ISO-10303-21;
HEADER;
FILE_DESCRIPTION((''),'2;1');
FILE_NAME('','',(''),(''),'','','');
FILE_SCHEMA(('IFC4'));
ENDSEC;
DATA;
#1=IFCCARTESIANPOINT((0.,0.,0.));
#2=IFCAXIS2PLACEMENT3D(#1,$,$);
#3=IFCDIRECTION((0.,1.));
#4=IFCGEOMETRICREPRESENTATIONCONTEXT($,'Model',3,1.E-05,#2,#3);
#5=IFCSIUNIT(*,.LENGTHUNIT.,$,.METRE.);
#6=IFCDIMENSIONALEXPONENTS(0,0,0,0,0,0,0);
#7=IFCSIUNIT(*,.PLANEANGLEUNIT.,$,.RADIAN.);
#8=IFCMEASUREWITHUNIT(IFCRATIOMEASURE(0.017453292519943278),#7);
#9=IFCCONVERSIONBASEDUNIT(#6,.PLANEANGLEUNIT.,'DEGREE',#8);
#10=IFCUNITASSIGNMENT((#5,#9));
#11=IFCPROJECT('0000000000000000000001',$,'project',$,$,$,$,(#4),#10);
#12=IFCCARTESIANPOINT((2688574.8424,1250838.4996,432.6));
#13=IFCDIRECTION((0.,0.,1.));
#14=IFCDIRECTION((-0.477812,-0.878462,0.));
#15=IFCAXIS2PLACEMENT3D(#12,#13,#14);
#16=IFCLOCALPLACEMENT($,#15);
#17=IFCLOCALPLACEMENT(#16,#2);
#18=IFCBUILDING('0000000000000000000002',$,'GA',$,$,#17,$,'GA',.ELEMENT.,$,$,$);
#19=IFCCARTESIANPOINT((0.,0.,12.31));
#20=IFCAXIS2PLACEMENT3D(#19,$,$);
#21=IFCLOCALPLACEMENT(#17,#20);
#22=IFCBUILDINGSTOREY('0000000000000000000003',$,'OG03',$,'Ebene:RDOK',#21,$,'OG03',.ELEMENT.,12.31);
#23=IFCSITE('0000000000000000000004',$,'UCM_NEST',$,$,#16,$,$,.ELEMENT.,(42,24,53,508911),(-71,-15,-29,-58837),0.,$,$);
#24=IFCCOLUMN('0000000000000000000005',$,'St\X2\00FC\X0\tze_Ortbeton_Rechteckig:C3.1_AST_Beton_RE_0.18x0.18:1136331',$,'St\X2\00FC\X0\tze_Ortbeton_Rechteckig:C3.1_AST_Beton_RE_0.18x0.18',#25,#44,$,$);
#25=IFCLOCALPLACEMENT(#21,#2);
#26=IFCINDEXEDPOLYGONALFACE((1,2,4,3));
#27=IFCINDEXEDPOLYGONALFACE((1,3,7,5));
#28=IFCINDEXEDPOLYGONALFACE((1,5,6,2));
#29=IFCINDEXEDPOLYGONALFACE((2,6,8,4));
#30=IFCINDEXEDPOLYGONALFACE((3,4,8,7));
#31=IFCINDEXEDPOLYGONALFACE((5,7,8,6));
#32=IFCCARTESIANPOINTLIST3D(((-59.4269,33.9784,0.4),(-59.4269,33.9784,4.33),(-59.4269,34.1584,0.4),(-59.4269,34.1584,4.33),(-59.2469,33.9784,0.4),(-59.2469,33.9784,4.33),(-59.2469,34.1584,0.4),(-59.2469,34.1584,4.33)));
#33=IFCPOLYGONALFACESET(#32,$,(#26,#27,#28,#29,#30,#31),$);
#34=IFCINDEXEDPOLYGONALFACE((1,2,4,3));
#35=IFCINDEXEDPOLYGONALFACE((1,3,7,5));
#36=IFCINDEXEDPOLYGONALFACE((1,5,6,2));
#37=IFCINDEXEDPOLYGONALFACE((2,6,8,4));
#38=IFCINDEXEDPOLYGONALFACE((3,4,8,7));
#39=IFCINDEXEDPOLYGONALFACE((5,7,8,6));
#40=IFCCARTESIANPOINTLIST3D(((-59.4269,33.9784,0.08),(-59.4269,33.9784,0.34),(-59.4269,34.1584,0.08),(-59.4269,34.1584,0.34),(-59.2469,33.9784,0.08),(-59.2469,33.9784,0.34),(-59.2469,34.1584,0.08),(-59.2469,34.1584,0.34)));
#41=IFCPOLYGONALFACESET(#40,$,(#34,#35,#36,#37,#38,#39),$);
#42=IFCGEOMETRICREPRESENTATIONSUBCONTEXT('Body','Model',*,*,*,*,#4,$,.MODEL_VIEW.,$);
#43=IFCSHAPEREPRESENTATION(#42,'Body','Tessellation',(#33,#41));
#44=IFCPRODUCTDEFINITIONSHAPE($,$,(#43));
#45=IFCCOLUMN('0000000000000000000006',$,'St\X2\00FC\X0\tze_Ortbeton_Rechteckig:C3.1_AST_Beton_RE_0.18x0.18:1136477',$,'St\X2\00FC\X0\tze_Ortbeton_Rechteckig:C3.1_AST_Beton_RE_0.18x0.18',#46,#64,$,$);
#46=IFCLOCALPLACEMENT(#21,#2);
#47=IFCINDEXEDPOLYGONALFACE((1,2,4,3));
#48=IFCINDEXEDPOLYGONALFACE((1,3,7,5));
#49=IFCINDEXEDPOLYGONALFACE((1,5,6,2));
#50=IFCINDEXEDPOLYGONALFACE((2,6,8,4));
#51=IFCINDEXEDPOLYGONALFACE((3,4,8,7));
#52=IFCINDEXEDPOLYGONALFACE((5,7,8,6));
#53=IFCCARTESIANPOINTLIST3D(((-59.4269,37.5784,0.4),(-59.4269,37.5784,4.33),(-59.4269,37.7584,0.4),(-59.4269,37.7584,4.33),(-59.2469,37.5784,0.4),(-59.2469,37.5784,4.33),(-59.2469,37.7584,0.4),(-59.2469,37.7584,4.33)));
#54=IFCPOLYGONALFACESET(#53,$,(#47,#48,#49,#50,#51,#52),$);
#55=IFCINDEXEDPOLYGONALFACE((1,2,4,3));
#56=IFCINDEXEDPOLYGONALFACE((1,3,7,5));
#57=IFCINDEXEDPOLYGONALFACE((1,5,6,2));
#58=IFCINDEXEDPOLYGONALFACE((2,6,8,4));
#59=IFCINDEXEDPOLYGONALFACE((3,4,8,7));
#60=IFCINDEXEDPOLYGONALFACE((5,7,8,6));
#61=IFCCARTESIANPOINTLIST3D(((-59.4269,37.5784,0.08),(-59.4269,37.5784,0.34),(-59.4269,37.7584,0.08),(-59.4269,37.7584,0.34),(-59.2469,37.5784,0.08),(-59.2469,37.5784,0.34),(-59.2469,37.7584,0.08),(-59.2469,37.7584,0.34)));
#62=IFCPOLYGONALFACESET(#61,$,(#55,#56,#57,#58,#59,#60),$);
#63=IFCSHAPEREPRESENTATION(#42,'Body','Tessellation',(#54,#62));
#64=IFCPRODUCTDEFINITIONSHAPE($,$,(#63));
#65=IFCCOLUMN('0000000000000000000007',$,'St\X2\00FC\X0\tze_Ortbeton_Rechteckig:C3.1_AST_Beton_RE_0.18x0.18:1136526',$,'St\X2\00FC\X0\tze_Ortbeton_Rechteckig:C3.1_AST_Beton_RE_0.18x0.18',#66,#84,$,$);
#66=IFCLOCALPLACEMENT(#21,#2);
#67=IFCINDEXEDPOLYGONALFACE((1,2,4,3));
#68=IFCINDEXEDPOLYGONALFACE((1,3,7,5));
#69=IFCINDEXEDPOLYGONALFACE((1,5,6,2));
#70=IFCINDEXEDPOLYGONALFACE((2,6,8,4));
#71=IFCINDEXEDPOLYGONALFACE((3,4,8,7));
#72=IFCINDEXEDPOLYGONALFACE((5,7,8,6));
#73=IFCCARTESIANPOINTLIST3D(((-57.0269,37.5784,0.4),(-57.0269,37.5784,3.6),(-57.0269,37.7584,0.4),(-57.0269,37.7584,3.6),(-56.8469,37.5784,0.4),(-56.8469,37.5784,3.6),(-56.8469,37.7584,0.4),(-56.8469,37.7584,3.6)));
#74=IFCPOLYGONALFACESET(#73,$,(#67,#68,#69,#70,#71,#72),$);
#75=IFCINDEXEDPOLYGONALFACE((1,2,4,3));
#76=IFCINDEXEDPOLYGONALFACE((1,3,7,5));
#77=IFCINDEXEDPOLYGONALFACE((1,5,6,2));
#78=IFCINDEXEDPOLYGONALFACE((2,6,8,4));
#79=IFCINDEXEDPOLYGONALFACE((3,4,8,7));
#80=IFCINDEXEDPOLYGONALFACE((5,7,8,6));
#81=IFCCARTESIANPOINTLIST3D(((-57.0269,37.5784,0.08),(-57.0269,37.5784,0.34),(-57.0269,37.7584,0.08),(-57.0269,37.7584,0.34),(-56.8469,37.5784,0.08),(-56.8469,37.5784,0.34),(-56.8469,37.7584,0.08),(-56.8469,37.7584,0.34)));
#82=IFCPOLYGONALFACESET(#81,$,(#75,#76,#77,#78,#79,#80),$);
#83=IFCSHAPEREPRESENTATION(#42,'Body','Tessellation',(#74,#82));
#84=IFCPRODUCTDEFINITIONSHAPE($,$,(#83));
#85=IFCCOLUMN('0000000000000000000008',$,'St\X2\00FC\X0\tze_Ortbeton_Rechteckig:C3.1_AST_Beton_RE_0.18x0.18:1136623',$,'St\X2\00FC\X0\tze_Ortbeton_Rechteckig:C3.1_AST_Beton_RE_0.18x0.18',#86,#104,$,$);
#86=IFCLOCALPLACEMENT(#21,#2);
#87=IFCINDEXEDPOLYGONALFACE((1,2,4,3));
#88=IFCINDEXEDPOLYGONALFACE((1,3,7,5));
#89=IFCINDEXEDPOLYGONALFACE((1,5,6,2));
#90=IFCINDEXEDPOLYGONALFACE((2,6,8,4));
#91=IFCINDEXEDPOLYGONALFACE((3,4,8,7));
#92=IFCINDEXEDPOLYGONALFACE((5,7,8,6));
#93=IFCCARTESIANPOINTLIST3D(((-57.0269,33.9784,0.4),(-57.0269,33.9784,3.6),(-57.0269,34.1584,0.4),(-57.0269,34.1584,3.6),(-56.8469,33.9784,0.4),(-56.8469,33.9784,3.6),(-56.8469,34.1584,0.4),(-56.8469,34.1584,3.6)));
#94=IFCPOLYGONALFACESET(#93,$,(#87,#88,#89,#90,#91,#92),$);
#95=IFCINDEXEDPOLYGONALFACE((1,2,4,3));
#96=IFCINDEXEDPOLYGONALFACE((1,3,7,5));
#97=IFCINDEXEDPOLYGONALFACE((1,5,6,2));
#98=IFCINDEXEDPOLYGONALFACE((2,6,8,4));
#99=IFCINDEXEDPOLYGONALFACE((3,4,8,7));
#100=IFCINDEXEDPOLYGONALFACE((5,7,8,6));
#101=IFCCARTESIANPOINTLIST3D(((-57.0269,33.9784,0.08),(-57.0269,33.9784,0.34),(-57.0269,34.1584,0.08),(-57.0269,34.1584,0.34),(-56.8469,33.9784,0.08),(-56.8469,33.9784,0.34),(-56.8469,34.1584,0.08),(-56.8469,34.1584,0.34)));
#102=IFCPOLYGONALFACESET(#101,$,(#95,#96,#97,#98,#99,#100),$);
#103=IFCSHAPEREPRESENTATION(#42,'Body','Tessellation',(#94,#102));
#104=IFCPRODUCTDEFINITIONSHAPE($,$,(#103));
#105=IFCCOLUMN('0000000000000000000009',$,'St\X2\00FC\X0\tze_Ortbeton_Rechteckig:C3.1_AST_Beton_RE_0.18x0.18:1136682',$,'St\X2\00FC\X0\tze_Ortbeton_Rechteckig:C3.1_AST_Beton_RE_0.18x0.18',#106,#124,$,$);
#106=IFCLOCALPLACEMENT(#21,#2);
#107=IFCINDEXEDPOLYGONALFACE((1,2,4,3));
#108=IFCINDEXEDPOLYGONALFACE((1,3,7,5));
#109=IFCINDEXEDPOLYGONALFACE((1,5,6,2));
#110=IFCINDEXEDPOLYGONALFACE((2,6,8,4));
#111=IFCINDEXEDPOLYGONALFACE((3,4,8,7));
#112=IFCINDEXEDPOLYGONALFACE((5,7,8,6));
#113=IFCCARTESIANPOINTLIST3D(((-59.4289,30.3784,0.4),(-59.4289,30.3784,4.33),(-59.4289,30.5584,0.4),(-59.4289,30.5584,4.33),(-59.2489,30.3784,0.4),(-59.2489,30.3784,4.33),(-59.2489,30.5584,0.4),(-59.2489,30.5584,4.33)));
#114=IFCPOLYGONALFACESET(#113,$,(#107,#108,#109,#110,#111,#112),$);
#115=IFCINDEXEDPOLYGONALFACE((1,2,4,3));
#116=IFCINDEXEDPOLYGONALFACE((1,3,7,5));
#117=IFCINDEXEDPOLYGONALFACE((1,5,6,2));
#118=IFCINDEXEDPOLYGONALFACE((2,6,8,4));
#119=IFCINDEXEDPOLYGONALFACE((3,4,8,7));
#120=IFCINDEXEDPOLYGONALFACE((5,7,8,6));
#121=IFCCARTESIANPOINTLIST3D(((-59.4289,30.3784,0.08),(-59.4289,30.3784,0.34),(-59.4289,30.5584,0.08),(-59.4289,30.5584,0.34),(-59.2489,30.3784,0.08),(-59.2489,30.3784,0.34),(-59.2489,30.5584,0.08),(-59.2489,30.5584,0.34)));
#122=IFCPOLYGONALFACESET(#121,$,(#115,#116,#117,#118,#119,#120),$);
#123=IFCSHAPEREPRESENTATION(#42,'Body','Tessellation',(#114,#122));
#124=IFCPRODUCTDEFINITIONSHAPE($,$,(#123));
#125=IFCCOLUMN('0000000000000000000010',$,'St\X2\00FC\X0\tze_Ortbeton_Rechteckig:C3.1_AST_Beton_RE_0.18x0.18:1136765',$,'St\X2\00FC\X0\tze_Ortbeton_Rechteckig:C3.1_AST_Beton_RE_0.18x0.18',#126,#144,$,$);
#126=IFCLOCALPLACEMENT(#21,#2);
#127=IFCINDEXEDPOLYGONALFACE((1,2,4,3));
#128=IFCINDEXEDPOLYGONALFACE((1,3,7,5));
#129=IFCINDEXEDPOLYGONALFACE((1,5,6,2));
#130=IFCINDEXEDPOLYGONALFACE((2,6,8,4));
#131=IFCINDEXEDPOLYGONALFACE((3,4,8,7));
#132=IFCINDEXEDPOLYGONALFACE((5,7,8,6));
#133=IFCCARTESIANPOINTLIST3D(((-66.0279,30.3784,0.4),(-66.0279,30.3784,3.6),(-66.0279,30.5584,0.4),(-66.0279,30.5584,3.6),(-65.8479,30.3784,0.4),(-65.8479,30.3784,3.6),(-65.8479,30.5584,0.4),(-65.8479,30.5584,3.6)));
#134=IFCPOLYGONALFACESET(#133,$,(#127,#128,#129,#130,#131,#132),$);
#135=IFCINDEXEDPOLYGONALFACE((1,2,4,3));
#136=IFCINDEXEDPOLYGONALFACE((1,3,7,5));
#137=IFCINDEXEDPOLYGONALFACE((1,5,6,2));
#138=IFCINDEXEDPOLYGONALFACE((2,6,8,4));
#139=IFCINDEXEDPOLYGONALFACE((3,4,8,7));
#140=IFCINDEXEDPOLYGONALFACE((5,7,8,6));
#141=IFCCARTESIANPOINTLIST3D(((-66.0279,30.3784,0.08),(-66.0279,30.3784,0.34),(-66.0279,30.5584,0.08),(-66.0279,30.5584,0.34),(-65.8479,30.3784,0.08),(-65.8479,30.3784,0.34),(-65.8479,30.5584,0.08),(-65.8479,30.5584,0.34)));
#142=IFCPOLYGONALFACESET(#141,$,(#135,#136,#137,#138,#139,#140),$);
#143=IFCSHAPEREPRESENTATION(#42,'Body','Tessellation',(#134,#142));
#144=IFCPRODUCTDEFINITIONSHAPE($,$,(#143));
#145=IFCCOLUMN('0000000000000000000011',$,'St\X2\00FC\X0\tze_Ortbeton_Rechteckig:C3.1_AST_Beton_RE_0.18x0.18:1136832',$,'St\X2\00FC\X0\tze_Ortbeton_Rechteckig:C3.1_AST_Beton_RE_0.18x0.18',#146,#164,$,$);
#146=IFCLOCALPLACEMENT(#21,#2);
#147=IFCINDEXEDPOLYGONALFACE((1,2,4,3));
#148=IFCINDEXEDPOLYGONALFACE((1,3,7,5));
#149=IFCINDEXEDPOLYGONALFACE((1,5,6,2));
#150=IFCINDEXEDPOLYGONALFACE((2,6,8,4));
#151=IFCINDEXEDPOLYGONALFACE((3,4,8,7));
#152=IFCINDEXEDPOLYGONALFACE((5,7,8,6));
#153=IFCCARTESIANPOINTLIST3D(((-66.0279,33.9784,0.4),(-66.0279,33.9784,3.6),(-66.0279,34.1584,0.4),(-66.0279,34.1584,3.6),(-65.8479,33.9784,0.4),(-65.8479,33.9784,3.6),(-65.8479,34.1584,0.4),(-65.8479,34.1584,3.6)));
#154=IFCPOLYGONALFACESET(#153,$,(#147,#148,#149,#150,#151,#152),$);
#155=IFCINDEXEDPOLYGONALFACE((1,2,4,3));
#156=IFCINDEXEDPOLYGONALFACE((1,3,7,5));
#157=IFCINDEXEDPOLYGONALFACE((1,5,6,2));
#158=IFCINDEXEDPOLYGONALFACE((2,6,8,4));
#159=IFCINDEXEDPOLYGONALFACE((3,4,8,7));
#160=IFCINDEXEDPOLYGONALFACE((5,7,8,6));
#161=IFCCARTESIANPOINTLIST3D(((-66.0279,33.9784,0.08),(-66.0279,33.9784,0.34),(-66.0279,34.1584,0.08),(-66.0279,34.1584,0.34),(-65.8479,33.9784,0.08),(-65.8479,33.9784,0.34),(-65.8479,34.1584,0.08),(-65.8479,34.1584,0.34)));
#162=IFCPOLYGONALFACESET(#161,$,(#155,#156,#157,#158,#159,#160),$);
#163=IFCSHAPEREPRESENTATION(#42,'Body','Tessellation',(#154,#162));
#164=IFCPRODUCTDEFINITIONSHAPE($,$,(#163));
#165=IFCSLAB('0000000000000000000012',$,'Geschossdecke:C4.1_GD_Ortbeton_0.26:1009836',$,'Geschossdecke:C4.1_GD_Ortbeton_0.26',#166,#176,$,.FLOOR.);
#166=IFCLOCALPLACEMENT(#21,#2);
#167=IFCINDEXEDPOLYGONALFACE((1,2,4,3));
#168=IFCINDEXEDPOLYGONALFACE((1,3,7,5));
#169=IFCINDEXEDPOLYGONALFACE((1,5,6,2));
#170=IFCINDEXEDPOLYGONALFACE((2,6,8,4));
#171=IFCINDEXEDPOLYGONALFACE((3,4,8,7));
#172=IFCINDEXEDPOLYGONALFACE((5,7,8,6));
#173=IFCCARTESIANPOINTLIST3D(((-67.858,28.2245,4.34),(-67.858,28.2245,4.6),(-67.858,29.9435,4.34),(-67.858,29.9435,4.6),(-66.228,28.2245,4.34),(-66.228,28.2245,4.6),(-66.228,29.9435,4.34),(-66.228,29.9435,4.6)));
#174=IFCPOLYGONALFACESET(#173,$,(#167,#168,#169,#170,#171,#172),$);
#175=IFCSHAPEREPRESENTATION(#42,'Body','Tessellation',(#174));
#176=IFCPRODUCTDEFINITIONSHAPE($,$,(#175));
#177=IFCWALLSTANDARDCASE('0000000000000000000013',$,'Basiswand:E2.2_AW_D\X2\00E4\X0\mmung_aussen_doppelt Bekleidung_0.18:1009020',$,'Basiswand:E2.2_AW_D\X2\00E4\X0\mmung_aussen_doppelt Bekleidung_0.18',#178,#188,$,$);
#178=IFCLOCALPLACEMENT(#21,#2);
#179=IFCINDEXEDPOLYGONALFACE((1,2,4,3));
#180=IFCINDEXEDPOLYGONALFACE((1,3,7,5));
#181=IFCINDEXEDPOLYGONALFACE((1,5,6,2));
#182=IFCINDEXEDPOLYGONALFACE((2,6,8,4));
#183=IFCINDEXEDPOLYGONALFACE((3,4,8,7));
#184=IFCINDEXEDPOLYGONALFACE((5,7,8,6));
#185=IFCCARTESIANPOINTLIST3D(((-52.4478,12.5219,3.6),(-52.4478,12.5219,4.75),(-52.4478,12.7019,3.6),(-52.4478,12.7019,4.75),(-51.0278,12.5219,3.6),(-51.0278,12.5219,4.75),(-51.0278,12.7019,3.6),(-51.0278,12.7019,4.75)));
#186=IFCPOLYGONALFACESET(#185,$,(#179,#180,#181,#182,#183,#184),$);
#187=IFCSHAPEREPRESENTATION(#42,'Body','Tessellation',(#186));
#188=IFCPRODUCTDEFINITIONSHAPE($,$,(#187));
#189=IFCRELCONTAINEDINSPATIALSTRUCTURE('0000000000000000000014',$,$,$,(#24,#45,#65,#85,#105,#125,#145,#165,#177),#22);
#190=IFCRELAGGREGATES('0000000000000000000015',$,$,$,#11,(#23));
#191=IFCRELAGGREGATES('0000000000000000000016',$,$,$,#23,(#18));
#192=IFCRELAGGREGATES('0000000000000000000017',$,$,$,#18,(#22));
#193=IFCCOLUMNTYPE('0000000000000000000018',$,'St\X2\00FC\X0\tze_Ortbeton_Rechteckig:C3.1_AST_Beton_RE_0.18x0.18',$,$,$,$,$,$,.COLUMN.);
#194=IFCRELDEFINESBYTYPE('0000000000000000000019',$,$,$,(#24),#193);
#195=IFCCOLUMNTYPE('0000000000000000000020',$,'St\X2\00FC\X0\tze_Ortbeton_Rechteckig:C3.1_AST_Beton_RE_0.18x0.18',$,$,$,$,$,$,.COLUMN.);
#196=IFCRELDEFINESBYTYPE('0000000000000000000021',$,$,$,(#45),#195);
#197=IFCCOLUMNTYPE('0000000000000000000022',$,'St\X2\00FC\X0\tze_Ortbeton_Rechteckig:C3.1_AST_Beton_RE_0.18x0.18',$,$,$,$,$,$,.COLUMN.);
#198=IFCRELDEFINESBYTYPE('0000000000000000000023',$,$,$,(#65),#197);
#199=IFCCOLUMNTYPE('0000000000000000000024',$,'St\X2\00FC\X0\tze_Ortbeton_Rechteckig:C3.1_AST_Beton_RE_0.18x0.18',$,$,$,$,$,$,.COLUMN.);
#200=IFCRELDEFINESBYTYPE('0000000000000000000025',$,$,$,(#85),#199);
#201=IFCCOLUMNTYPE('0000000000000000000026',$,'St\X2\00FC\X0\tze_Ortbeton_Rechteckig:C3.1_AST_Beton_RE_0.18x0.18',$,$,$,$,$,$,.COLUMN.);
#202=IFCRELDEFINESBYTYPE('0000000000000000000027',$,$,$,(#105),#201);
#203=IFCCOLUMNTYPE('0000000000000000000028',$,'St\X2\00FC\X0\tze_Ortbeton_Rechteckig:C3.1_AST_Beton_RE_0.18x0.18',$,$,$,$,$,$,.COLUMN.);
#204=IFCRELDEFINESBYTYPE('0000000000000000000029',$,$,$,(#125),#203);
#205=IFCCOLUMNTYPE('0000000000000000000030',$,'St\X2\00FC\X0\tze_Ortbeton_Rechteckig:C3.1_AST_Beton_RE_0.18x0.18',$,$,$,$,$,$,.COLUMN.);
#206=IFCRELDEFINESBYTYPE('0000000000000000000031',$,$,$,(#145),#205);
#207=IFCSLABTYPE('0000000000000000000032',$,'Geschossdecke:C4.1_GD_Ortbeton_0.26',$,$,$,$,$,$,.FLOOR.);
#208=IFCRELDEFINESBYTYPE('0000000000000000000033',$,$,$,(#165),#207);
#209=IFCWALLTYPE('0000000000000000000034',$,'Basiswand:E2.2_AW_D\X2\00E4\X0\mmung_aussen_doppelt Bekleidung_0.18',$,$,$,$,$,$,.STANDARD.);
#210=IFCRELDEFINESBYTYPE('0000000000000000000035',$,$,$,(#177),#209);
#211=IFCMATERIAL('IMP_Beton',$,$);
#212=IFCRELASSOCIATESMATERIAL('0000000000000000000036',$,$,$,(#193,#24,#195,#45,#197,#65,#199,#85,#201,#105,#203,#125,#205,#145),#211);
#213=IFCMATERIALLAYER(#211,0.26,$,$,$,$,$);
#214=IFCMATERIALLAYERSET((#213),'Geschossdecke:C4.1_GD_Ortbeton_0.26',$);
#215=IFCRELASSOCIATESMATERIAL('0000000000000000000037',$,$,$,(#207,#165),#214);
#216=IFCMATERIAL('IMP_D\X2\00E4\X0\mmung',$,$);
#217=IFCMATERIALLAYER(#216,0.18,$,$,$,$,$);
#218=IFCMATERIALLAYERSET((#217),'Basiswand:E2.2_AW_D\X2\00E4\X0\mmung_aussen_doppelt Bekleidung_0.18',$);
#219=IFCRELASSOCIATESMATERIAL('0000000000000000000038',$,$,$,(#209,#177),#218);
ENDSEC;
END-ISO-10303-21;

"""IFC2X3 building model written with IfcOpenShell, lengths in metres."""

from ifc_helpers import new_model, entity, si_unit, converted_unit, direction, frame, frame_2d, origin, origin_2d_with_axis, place, context, subcontext, project, spatial, rectangle, extrude, source, transform, mapped, material, layer, layer_set, layer_usage, type_object, type_shapes, element, save


model = new_model("IFC2X3")

# Units and contexts
model_context = context("Model", 3, precision=1e-05, world=origin(), true_north=direction((0.0, 1.0)))
body_context = subcontext(model_context, "Body", "Model", "MODEL_VIEW")
ifc_project = project(units=[si_unit("LENGTHUNIT", "METRE"), converted_unit("PLANEANGLEUNIT", "DEGREE", entity("IfcRatioMeasure", 0.017453292519943278), si_unit("PLANEANGLEUNIT", "RADIAN"), dimensions=[0, 0, 0, 0, 0, 0, 0])], contexts=[model_context])

# Site, building, storey
site_placement = place(None, frame((2688574.8424, 1250838.4996, 432.6), z_axis=(0.0, 0.0, 1.0), x_axis=(-0.477812, -0.878462, 0.0)))
site = spatial("IfcSite", under=ifc_project, at=site_placement, Name="UCM_NEST", CompositionType="ELEMENT", RefLatitude=(42, 24, 53, 508911), RefLongitude=(-71, -15, -29, -58837), RefElevation=0.0)
building_placement = place(site_placement, origin())
building = spatial("IfcBuilding", under=site, at=building_placement, Name="GA", LongName="GA", CompositionType="ELEMENT")
storey_placement = place(building_placement, frame((0.0, 0.0, 12.31)))
storey = spatial("IfcBuildingStorey", under=building, at=storey_placement, Name="OG03", ObjectType="Ebene:RDOK", LongName="OG03", CompositionType="ELEMENT", Elevation=12.31)

# Columns
ifc_material_1 = material(Name="IMP_Beton")
column_type_1 = type_object("IfcColumnType", Name="Stütze_Ortbeton_Rechteckig:C3.1_AST_Beton_RE_0.18x0.18", PredefinedType="COLUMN", material=ifc_material_1)
shared_shape_1 = source(origin(), body_context, "Body", "SweptSolid", [
    extrude(rectangle(XDim=0.18, YDim=0.18, at=frame_2d((0.0, 0.0), x_axis=(1.0, 0.0))), frame((-59.3369, 34.0684, 12.71), z_axis=(0.0, 0.0, 1.0), x_axis=(0.0, -1.0, 0.0)), (0.0, 0.0, 1.0), 3.93),
    extrude(rectangle(XDim=0.18, YDim=0.18, at=frame_2d((0.0, 0.0), x_axis=(1.0, 0.0))), frame((-59.3369, 34.0684, 12.39), z_axis=(0.0, 0.0, 1.0), x_axis=(0.0, -1.0, 0.0)), (0.0, 0.0, 1.0), 0.26),
])
type_shapes(column_type_1, [shared_shape_1])
column_1_placement = place(storey_placement, frame((0.0, 0.0, -12.31)))
element("IfcColumn", 1, at=column_1_placement, inside=storey, type_object=column_type_1, material=ifc_material_1, Name="Stütze_Ortbeton_Rechteckig:C3.1_AST_Beton_RE_0.18x0.18:1136331", ObjectType="Stütze_Ortbeton_Rechteckig:C3.1_AST_Beton_RE_0.18x0.18", context=body_context, shape_type="MappedRepresentation", body=[
    mapped(shared_shape_1, transform((0.0, 0.0, 0.0), scale=1.0)),
])
column_type_2 = type_object("IfcColumnType", Name="Stütze_Ortbeton_Rechteckig:C3.1_AST_Beton_RE_0.18x0.18", PredefinedType="COLUMN", material=ifc_material_1)
shared_shape_2 = source(origin(), body_context, "Body", "SweptSolid", [
    extrude(rectangle(XDim=0.18, YDim=0.18, at=frame_2d((0.0, 0.0), x_axis=(1.0, 0.0))), frame((-59.3369, 37.6684, 12.71), z_axis=(0.0, 0.0, 1.0), x_axis=(0.0, -1.0, 0.0)), (0.0, 0.0, 1.0), 3.93),
    extrude(rectangle(XDim=0.18, YDim=0.18, at=frame_2d((0.0, 0.0), x_axis=(1.0, 0.0))), frame((-59.3369, 37.6684, 12.39), z_axis=(0.0, 0.0, 1.0), x_axis=(0.0, -1.0, 0.0)), (0.0, 0.0, 1.0), 0.26),
])
type_shapes(column_type_2, [shared_shape_2])
column_2_placement = place(storey_placement, frame((0.0, 0.0, -12.31)))
element("IfcColumn", 2, at=column_2_placement, inside=storey, type_object=column_type_2, material=ifc_material_1, Name="Stütze_Ortbeton_Rechteckig:C3.1_AST_Beton_RE_0.18x0.18:1136477", ObjectType="Stütze_Ortbeton_Rechteckig:C3.1_AST_Beton_RE_0.18x0.18", context=body_context, shape_type="MappedRepresentation", body=[
    mapped(shared_shape_2, transform((0.0, 0.0, 0.0), scale=1.0)),
])
column_type_3 = type_object("IfcColumnType", Name="Stütze_Ortbeton_Rechteckig:C3.1_AST_Beton_RE_0.18x0.18", PredefinedType="COLUMN", material=ifc_material_1)
shared_shape_3 = source(origin(), body_context, "Body", "SweptSolid", [
    extrude(rectangle(XDim=0.18, YDim=0.18, at=origin_2d_with_axis()), frame((-56.9369, 37.6684, 12.71), z_axis=(0.0, 0.0, 1.0), x_axis=(0.0, -1.0, 0.0)), (0.0, 0.0, 1.0), 3.2),
    extrude(rectangle(XDim=0.18, YDim=0.18, at=origin_2d_with_axis()), frame((-56.9369, 37.6684, 12.39), z_axis=(0.0, 0.0, 1.0), x_axis=(0.0, -1.0, 0.0)), (0.0, 0.0, 1.0), 0.26),
])
type_shapes(column_type_3, [shared_shape_3])
column_3_placement = place(storey_placement, frame((0.0, 0.0, -12.31)))
element("IfcColumn", 3, at=column_3_placement, inside=storey, type_object=column_type_3, material=ifc_material_1, Name="Stütze_Ortbeton_Rechteckig:C3.1_AST_Beton_RE_0.18x0.18:1136526", ObjectType="Stütze_Ortbeton_Rechteckig:C3.1_AST_Beton_RE_0.18x0.18", context=body_context, shape_type="MappedRepresentation", body=[
    mapped(shared_shape_3, transform((0.0, 0.0, 0.0), scale=1.0)),
])
column_type_4 = type_object("IfcColumnType", Name="Stütze_Ortbeton_Rechteckig:C3.1_AST_Beton_RE_0.18x0.18", PredefinedType="COLUMN", material=ifc_material_1)
shared_shape_4 = source(origin(), body_context, "Body", "SweptSolid", [
    extrude(rectangle(XDim=0.18, YDim=0.18, at=frame_2d((0.0, 0.0), x_axis=(1.0, 0.0))), frame((-56.9369, 34.0684, 12.71), z_axis=(0.0, 0.0, 1.0), x_axis=(0.0, -1.0, 0.0)), (0.0, 0.0, 1.0), 3.2),
    extrude(rectangle(XDim=0.18, YDim=0.18, at=frame_2d((0.0, 0.0), x_axis=(1.0, 0.0))), frame((-56.9369, 34.0684, 12.39), z_axis=(0.0, 0.0, 1.0), x_axis=(0.0, -1.0, 0.0)), (0.0, 0.0, 1.0), 0.26),
])
type_shapes(column_type_4, [shared_shape_4])
column_4_placement = place(storey_placement, frame((0.0, 0.0, -12.31)))
element("IfcColumn", 4, at=column_4_placement, inside=storey, type_object=column_type_4, material=ifc_material_1, Name="Stütze_Ortbeton_Rechteckig:C3.1_AST_Beton_RE_0.18x0.18:1136623", ObjectType="Stütze_Ortbeton_Rechteckig:C3.1_AST_Beton_RE_0.18x0.18", context=body_context, shape_type="MappedRepresentation", body=[
    mapped(shared_shape_4, transform((0.0, 0.0, 0.0), scale=1.0)),
])
column_type_5 = type_object("IfcColumnType", Name="Stütze_Ortbeton_Rechteckig:C3.1_AST_Beton_RE_0.18x0.18", PredefinedType="COLUMN", material=ifc_material_1)
shared_shape_5 = source(origin(), body_context, "Body", "SweptSolid", [
    extrude(rectangle(XDim=0.18, YDim=0.18, at=frame_2d((0.0, 0.0), x_axis=(1.0, 0.0))), frame((-59.3389, 30.4684, 12.71), z_axis=(0.0, 0.0, 1.0), x_axis=(0.0, -1.0, 0.0)), (0.0, 0.0, 1.0), 3.93),
    extrude(rectangle(XDim=0.18, YDim=0.18, at=frame_2d((0.0, 0.0), x_axis=(1.0, 0.0))), frame((-59.3389, 30.4684, 12.39), z_axis=(0.0, 0.0, 1.0), x_axis=(0.0, -1.0, 0.0)), (0.0, 0.0, 1.0), 0.26),
])
type_shapes(column_type_5, [shared_shape_5])
column_5_placement = place(storey_placement, frame((0.0, 0.0, -12.31)))
element("IfcColumn", 5, at=column_5_placement, inside=storey, type_object=column_type_5, material=ifc_material_1, Name="Stütze_Ortbeton_Rechteckig:C3.1_AST_Beton_RE_0.18x0.18:1136682", ObjectType="Stütze_Ortbeton_Rechteckig:C3.1_AST_Beton_RE_0.18x0.18", context=body_context, shape_type="MappedRepresentation", body=[
    mapped(shared_shape_5, transform((0.0, 0.0, 0.0), scale=1.0)),
])
column_type_6 = type_object("IfcColumnType", Name="Stütze_Ortbeton_Rechteckig:C3.1_AST_Beton_RE_0.18x0.18", PredefinedType="COLUMN", material=ifc_material_1)
shared_shape_6 = source(origin(), body_context, "Body", "SweptSolid", [
    extrude(rectangle(XDim=0.18, YDim=0.18, at=origin_2d_with_axis()), frame((-65.9379, 30.4684, 12.71), z_axis=(0.0, 0.0, 1.0), x_axis=(0.0, -1.0, 0.0)), (0.0, 0.0, 1.0), 3.2),
    extrude(rectangle(XDim=0.18, YDim=0.18, at=origin_2d_with_axis()), frame((-65.9379, 30.4684, 12.39), z_axis=(0.0, 0.0, 1.0), x_axis=(0.0, -1.0, 0.0)), (0.0, 0.0, 1.0), 0.26),
])
type_shapes(column_type_6, [shared_shape_6])
column_6_placement = place(storey_placement, frame((0.0, 0.0, -12.31)))
element("IfcColumn", 6, at=column_6_placement, inside=storey, type_object=column_type_6, material=ifc_material_1, Name="Stütze_Ortbeton_Rechteckig:C3.1_AST_Beton_RE_0.18x0.18:1136765", ObjectType="Stütze_Ortbeton_Rechteckig:C3.1_AST_Beton_RE_0.18x0.18", context=body_context, shape_type="MappedRepresentation", body=[
    mapped(shared_shape_6, transform((0.0, 0.0, 0.0), scale=1.0)),
])
column_type_7 = type_object("IfcColumnType", Name="Stütze_Ortbeton_Rechteckig:C3.1_AST_Beton_RE_0.18x0.18", PredefinedType="COLUMN", material=ifc_material_1)
shared_shape_7 = source(origin(), body_context, "Body", "SweptSolid", [
    extrude(rectangle(XDim=0.18, YDim=0.18, at=origin_2d_with_axis()), frame((-65.9379, 34.0684, 12.71), z_axis=(0.0, 0.0, 1.0), x_axis=(0.0, -1.0, 0.0)), (0.0, 0.0, 1.0), 3.2),
    extrude(rectangle(XDim=0.18, YDim=0.18, at=origin_2d_with_axis()), frame((-65.9379, 34.0684, 12.39), z_axis=(0.0, 0.0, 1.0), x_axis=(0.0, -1.0, 0.0)), (0.0, 0.0, 1.0), 0.26),
])
type_shapes(column_type_7, [shared_shape_7])
column_7_placement = place(storey_placement, frame((0.0, 0.0, -12.31)))
element("IfcColumn", 7, at=column_7_placement, inside=storey, type_object=column_type_7, material=ifc_material_1, Name="Stütze_Ortbeton_Rechteckig:C3.1_AST_Beton_RE_0.18x0.18:1136832", ObjectType="Stütze_Ortbeton_Rechteckig:C3.1_AST_Beton_RE_0.18x0.18", context=body_context, shape_type="MappedRepresentation", body=[
    mapped(shared_shape_7, transform((0.0, 0.0, 0.0), scale=1.0)),
])

# Slab
ifc_layer_1 = layer(ifc_material_1, 0.26)
ifc_layer_set_1 = layer_set([ifc_layer_1], Name="Geschossdecke:C4.1_GD_Ortbeton_0.26")
ifc_layer_usage_1 = layer_usage(ifc_layer_set_1, "AXIS3", "POSITIVE", 0.0)
slab_type_1 = type_object("IfcSlabType", Name="Geschossdecke:C4.1_GD_Ortbeton_0.26", PredefinedType="FLOOR", material=ifc_layer_set_1)
slab_1_placement = place(storey_placement, origin())
element("IfcSlab", 8, at=slab_1_placement, inside=storey, type_object=slab_type_1, material=ifc_layer_usage_1, Name="Geschossdecke:C4.1_GD_Ortbeton_0.26:1009836", ObjectType="Geschossdecke:C4.1_GD_Ortbeton_0.26", PredefinedType="FLOOR", context=body_context, shape_type="SweptSolid", body=[
    extrude(rectangle(XDim=1.719, YDim=1.63, at=frame_2d((0.0, 0.0), x_axis=(1.0, 0.0))), frame((-67.043, 29.084, 4.6), z_axis=(0.0, 0.0, -1.0), x_axis=(0.0, 1.0, 0.0)), (0.0, 0.0, 1.0), 0.26),
])
ifc_material_2 = material(Name="IMP_Dämmung")

# Wall
ifc_layer_2 = layer(ifc_material_2, 0.18)
ifc_layer_set_2 = layer_set([ifc_layer_2], Name="Basiswand:E2.2_AW_Dämmung_aussen_doppelt Bekleidung_0.18")
ifc_layer_usage_2 = layer_usage(ifc_layer_set_2, "AXIS2", "NEGATIVE", 0.09)
wall_type_1 = type_object("IfcWallType", Name="Basiswand:E2.2_AW_Dämmung_aussen_doppelt Bekleidung_0.18", PredefinedType="STANDARD", material=ifc_layer_set_2)
wall_1_placement = place(storey_placement, frame((-52.4478, 12.6119, 3.6)))
element("IfcWallStandardCase", 9, at=wall_1_placement, inside=storey, type_object=wall_type_1, material=ifc_layer_usage_2, Name="Basiswand:E2.2_AW_Dämmung_aussen_doppelt Bekleidung_0.18:1009020", ObjectType="Basiswand:E2.2_AW_Dämmung_aussen_doppelt Bekleidung_0.18", context=body_context, shape_type="SweptSolid", body=[
    extrude(rectangle(XDim=1.42, YDim=0.18, at=frame_2d((0.71, 0.0), x_axis=(-1.0, 0.0))), origin(), (0.0, 0.0, 1.0), 1.15),
])

save(model, "model.ifc")
